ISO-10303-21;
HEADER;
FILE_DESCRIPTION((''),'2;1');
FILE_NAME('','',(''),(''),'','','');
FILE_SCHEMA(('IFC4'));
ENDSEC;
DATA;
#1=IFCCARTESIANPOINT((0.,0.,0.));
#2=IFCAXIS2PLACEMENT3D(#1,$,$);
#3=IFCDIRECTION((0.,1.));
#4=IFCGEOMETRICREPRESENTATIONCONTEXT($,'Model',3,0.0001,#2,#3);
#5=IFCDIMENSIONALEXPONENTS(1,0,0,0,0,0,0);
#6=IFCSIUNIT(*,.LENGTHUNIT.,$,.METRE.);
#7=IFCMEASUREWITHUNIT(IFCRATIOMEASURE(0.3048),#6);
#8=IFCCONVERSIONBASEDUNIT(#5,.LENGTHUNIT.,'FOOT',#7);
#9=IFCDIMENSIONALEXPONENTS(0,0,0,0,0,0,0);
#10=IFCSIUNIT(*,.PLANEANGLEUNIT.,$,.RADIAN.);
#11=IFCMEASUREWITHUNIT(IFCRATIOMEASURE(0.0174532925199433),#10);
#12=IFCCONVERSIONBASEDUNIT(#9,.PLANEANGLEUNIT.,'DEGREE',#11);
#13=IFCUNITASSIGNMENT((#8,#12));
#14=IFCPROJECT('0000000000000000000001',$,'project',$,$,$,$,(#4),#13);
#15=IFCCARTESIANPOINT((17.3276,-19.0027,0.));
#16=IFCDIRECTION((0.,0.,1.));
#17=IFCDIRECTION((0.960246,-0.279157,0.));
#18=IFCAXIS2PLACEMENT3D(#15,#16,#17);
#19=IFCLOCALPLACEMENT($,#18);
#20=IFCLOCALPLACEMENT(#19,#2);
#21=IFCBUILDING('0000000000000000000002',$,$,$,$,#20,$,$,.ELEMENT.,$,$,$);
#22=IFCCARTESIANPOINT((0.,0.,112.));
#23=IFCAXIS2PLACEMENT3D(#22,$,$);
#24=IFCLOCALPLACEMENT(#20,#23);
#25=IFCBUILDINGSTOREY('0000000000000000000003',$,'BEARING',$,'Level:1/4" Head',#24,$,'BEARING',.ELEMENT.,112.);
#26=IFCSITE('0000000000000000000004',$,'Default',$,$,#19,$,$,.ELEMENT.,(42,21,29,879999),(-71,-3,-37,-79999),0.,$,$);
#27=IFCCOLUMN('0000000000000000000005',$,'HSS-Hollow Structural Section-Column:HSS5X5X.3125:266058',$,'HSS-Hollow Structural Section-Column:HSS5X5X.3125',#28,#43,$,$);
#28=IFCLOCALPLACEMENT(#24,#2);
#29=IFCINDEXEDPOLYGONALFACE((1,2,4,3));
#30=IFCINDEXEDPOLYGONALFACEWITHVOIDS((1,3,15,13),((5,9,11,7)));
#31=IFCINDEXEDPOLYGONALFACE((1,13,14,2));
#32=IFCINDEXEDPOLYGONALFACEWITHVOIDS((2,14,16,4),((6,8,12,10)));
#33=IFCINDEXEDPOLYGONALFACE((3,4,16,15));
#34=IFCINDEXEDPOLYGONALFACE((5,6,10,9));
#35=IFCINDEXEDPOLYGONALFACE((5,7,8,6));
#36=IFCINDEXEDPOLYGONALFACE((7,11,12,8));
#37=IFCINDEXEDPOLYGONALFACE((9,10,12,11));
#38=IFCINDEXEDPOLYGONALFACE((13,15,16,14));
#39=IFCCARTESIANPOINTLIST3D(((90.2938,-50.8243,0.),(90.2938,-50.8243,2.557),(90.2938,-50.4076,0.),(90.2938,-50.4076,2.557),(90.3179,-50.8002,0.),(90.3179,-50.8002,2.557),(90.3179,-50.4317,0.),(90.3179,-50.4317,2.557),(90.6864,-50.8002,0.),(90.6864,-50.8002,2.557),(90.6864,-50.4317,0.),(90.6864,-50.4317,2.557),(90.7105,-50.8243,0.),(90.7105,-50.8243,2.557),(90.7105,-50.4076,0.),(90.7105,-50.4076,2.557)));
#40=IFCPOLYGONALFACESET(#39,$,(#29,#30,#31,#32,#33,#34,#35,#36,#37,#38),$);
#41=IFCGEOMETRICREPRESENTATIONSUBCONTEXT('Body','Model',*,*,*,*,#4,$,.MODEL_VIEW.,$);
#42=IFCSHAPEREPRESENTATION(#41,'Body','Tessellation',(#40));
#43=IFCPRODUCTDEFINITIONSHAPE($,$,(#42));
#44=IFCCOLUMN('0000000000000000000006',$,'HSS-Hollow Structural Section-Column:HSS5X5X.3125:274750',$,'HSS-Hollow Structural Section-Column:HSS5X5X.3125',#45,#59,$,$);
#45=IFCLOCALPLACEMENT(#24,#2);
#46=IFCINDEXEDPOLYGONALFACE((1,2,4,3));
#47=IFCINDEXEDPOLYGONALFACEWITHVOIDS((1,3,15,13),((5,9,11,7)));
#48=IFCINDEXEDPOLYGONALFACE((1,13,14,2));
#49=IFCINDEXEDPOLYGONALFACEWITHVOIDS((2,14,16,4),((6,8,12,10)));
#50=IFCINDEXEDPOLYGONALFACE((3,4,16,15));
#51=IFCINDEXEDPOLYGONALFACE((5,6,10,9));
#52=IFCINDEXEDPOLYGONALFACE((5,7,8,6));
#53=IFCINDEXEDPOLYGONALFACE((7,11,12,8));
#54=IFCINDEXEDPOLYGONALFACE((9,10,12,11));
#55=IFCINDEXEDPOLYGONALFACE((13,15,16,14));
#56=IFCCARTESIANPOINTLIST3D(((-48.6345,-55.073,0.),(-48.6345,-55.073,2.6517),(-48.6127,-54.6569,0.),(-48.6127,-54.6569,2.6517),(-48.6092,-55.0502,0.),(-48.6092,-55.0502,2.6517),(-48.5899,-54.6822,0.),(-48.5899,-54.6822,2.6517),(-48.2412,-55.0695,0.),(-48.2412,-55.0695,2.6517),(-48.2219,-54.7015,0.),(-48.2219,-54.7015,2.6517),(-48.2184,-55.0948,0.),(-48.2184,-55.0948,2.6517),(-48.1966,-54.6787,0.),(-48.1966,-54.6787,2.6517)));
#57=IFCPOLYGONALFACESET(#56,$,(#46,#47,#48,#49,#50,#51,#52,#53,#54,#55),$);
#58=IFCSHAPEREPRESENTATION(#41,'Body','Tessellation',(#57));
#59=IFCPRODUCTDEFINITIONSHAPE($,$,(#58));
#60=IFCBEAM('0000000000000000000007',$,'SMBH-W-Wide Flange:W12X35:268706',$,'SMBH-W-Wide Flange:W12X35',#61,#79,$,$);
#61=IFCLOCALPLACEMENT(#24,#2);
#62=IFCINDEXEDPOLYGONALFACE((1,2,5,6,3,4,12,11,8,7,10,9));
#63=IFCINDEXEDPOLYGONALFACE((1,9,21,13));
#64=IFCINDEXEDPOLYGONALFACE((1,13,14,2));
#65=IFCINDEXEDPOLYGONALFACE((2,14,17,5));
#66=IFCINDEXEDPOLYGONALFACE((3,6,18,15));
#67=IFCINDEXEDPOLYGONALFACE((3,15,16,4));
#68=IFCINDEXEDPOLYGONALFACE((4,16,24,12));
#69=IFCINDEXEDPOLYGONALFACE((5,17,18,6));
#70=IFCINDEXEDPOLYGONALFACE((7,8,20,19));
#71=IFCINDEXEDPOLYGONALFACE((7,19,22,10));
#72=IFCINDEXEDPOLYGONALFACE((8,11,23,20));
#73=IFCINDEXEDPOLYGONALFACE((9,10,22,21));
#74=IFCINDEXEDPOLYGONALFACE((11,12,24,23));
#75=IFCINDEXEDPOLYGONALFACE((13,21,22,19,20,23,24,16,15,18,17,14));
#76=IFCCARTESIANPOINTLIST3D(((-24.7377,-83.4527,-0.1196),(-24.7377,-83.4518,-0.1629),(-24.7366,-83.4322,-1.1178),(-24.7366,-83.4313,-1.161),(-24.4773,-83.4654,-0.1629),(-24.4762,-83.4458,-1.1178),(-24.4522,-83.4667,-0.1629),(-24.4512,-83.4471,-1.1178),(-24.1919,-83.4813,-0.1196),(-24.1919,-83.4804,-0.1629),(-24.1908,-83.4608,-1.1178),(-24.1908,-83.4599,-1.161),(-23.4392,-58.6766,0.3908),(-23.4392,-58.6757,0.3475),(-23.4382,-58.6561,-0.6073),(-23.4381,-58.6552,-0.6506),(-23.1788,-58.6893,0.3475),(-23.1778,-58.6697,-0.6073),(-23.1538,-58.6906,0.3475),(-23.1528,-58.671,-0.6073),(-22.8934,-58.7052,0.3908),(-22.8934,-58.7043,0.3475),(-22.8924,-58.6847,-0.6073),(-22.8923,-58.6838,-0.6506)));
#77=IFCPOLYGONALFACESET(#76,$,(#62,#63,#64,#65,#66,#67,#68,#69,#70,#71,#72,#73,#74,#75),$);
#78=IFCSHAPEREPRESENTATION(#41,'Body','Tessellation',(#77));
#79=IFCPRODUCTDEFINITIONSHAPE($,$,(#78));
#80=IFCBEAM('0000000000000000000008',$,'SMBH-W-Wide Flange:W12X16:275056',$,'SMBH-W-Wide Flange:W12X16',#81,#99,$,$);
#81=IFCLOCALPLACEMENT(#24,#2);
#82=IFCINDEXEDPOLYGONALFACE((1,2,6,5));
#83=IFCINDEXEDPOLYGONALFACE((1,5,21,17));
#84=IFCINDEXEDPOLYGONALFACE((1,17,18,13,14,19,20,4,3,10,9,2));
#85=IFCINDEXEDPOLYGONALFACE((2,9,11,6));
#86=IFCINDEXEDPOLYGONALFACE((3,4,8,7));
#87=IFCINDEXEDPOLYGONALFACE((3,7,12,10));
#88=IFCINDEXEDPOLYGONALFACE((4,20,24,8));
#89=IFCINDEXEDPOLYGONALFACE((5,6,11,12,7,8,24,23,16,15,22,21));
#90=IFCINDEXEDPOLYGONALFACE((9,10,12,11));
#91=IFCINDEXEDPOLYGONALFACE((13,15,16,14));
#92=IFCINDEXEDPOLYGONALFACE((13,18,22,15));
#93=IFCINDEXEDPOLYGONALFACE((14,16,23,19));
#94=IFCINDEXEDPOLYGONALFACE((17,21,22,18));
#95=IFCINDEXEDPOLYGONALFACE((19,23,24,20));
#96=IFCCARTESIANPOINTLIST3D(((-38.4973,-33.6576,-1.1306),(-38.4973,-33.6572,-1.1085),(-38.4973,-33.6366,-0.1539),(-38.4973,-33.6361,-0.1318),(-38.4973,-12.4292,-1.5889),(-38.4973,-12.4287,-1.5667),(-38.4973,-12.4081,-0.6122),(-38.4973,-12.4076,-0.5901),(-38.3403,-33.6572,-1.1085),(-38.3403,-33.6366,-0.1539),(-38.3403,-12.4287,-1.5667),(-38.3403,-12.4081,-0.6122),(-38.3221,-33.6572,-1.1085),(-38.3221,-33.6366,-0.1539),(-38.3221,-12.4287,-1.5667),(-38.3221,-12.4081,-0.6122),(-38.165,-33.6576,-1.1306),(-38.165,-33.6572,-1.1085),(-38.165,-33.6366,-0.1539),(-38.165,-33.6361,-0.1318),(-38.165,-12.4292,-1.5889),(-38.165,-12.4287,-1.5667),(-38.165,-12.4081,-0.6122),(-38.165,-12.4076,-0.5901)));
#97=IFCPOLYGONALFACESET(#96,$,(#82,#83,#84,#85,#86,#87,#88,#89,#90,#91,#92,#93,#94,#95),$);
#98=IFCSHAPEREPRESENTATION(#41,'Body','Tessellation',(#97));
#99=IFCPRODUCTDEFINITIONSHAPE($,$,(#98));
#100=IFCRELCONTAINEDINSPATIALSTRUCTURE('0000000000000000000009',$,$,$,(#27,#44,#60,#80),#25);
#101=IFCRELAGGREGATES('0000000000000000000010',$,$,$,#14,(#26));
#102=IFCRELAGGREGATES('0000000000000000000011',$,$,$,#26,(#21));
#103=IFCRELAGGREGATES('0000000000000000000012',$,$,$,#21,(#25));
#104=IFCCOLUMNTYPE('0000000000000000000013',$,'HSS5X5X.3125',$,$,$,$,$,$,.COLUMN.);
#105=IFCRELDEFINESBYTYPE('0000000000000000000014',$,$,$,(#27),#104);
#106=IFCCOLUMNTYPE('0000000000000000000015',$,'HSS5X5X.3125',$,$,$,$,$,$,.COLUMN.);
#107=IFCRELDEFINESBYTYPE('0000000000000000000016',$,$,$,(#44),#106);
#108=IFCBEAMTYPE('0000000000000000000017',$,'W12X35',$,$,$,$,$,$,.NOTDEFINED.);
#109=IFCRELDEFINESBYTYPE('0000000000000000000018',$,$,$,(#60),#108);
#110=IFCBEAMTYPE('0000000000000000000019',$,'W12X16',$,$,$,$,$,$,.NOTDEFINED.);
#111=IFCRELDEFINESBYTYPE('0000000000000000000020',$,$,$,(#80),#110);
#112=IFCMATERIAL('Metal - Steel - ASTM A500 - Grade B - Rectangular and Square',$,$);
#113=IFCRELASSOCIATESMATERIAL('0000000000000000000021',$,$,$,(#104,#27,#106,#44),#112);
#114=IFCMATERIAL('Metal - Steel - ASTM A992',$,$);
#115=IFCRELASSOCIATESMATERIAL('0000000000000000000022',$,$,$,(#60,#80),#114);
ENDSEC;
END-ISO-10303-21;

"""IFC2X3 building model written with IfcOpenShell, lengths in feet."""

from ifc_helpers import new_model, entity, si_unit, converted_unit, direction, frame, frame_2d, origin, origin_2d_with_axis, place, context, subcontext, project, spatial, rectangle, i_section, extrude, boolean, source, transform, mapped, material, type_object, type_shapes, element, save


model = new_model("IFC2X3")

# Units and contexts
model_context = context("Model", 3, precision=0.0001, world=origin(), true_north=direction((0.0, 1.0)))
body_context = subcontext(model_context, "Body", "Model", "MODEL_VIEW")
ifc_project = project(units=[converted_unit("LENGTHUNIT", "FOOT", entity("IfcRatioMeasure", 0.3048), si_unit("LENGTHUNIT", "METRE"), dimensions=[1, 0, 0, 0, 0, 0, 0]), converted_unit("PLANEANGLEUNIT", "DEGREE", entity("IfcRatioMeasure", 0.0174532925199433), si_unit("PLANEANGLEUNIT", "RADIAN"), dimensions=[0, 0, 0, 0, 0, 0, 0])], contexts=[model_context])

# Site, building, storey
site_placement = place(None, frame((17.3276, -19.0027, 0.0), z_axis=(0.0, 0.0, 1.0), x_axis=(0.960246, -0.279157, 0.0)))
site = spatial("IfcSite", under=ifc_project, at=site_placement, Name="Default", CompositionType="ELEMENT", RefLatitude=(42, 21, 29, 879999), RefLongitude=(-71, -3, -37, -79999), RefElevation=0.0)
building_placement = place(site_placement, origin())
building = spatial("IfcBuilding", under=site, at=building_placement, CompositionType="ELEMENT")
storey_placement = place(building_placement, frame((0.0, 0.0, 112.0)))
storey = spatial("IfcBuildingStorey", under=building, at=storey_placement, Name="BEARING", ObjectType="Level:1/4\" Head", LongName="BEARING", CompositionType="ELEMENT", Elevation=112.0)

# Columns
ifc_material_1 = material(Name="Metal - Steel - ASTM A500 - Grade B - Rectangular and Square")
column_type_1 = type_object("IfcColumnType", Name="HSS5X5X.3125", PredefinedType="COLUMN", material=ifc_material_1)
shared_shape_1 = source(origin(), body_context, "Body", "SweptSolid", [
    boolean("DIFFERENCE", extrude(rectangle(XDim=0.4167, YDim=0.4167, at=frame_2d((0.0, 0.0), x_axis=(1.0, 0.0))), frame((90.5022, -50.616, 112.0), z_axis=(0.0, 0.0, 1.0), x_axis=(0.0, -1.0, 0.0)), (0.0, 0.0, 1.0), 2.557), extrude(rectangle(XDim=0.3685, YDim=0.3685, at=frame_2d((0.0, 0.0), x_axis=(1.0, 0.0))), frame((90.5022, -50.616, 114.557), z_axis=(0.0, 0.0, -1.0), x_axis=(0.0, -1.0, 0.0)), (0.0, 0.0, 1.0), 2.557)),
])
type_shapes(column_type_1, [shared_shape_1])
column_1_placement = place(storey_placement, frame((0.0, 0.0, -112.0)))
element("IfcColumn", 1, at=column_1_placement, inside=storey, type_object=column_type_1, material=ifc_material_1, Name="HSS-Hollow Structural Section-Column:HSS5X5X.3125:266058", ObjectType="HSS-Hollow Structural Section-Column:HSS5X5X.3125", context=body_context, shape_type="MappedRepresentation", body=[
    mapped(shared_shape_1, transform((0.0, 0.0, 0.0), scale=1.0)),
])
column_type_2 = type_object("IfcColumnType", Name="HSS5X5X.3125", PredefinedType="COLUMN", material=ifc_material_1)
shared_shape_2 = source(origin(), body_context, "Body", "SweptSolid", [
    boolean("DIFFERENCE", extrude(rectangle(XDim=0.4167, YDim=0.4167, at=frame_2d((0.0, 0.0), x_axis=(1.0, 0.0))), frame((-48.4156, -54.8758, 112.0), z_axis=(0.0, 0.0, 1.0), x_axis=(-0.998629, 0.052347, 0.0)), (0.0, 0.0, 1.0), 2.6517), extrude(rectangle(XDim=0.3685, YDim=0.3685, at=origin_2d_with_axis()), frame((-48.4156, -54.8758, 114.6517), z_axis=(0.0, 0.0, -1.0), x_axis=(-0.052347, -0.998629, 0.0)), (0.0, 0.0, 1.0), 2.6517)),
])
type_shapes(column_type_2, [shared_shape_2])
column_2_placement = place(storey_placement, frame((0.0, 0.0, -112.0)))
element("IfcColumn", 2, at=column_2_placement, inside=storey, type_object=column_type_2, material=ifc_material_1, Name="HSS-Hollow Structural Section-Column:HSS5X5X.3125:274750", ObjectType="HSS-Hollow Structural Section-Column:HSS5X5X.3125", context=body_context, shape_type="MappedRepresentation", body=[
    mapped(shared_shape_2, transform((0.0, 0.0, 0.0), scale=1.0)),
])

# Beams
ifc_material_2 = material(Name="Metal - Steel - ASTM A992")
beam_type_1 = type_object("IfcBeamType", Name="W12X35", PredefinedType="NOTDEFINED")
beam_1_placement = place(storey_placement, frame((-24.4786, -83.7305, 0.0), z_axis=(-0.001077, -0.020541, 0.999788), x_axis=(0.052325, 0.998418, 0.020569)))
element("IfcBeam", 3, at=beam_1_placement, inside=storey, type_object=beam_type_1, material=ifc_material_2, Name="SMBH-W-Wide Flange:W12X35:268706", ObjectType="SMBH-W-Wide Flange:W12X35", context=body_context, shape_type="SweptSolid", body=[
    extrude(i_section(OverallWidth=0.5465, OverallDepth=1.0417, WebThickness=0.0251, FlangeThickness=0.0433, at=frame_2d((0.0, 0.0), x_axis=(0.0, 1.0))), frame((0.2614, 0.0, -0.6458), z_axis=(1.0, 0.0, 0.0), x_axis=(0.0, 0.0, -1.0)), (0.0, 0.0, 1.0), 24.8153),
])
beam_type_2 = type_object("IfcBeamType", Name="W12X16", PredefinedType="NOTDEFINED")
beam_2_placement = place(storey_placement, frame((-38.3312, -33.9493, 0.0), z_axis=(0.0, 0.021584, 0.999767), x_axis=(0.0, 0.999767, -0.021584)))
element("IfcBeam", 4, at=beam_2_placement, inside=storey, type_object=beam_type_2, material=ifc_material_2, Name="SMBH-W-Wide Flange:W12X16:275056", ObjectType="SMBH-W-Wide Flange:W12X16", context=body_context, shape_type="SweptSolid", body=[
    extrude(i_section(OverallWidth=0.3324, OverallDepth=0.999, WebThickness=0.0182, FlangeThickness=0.0221, at=frame_2d((0.0, 0.0), x_axis=(0.0, 1.0))), frame((0.316, 0.0, -0.6245), z_axis=(1.0, 0.0, 0.0), x_axis=(0.0, 0.0, -1.0)), (0.0, 0.0, 1.0), 21.2334),
])

save(model, "model.ifc")
